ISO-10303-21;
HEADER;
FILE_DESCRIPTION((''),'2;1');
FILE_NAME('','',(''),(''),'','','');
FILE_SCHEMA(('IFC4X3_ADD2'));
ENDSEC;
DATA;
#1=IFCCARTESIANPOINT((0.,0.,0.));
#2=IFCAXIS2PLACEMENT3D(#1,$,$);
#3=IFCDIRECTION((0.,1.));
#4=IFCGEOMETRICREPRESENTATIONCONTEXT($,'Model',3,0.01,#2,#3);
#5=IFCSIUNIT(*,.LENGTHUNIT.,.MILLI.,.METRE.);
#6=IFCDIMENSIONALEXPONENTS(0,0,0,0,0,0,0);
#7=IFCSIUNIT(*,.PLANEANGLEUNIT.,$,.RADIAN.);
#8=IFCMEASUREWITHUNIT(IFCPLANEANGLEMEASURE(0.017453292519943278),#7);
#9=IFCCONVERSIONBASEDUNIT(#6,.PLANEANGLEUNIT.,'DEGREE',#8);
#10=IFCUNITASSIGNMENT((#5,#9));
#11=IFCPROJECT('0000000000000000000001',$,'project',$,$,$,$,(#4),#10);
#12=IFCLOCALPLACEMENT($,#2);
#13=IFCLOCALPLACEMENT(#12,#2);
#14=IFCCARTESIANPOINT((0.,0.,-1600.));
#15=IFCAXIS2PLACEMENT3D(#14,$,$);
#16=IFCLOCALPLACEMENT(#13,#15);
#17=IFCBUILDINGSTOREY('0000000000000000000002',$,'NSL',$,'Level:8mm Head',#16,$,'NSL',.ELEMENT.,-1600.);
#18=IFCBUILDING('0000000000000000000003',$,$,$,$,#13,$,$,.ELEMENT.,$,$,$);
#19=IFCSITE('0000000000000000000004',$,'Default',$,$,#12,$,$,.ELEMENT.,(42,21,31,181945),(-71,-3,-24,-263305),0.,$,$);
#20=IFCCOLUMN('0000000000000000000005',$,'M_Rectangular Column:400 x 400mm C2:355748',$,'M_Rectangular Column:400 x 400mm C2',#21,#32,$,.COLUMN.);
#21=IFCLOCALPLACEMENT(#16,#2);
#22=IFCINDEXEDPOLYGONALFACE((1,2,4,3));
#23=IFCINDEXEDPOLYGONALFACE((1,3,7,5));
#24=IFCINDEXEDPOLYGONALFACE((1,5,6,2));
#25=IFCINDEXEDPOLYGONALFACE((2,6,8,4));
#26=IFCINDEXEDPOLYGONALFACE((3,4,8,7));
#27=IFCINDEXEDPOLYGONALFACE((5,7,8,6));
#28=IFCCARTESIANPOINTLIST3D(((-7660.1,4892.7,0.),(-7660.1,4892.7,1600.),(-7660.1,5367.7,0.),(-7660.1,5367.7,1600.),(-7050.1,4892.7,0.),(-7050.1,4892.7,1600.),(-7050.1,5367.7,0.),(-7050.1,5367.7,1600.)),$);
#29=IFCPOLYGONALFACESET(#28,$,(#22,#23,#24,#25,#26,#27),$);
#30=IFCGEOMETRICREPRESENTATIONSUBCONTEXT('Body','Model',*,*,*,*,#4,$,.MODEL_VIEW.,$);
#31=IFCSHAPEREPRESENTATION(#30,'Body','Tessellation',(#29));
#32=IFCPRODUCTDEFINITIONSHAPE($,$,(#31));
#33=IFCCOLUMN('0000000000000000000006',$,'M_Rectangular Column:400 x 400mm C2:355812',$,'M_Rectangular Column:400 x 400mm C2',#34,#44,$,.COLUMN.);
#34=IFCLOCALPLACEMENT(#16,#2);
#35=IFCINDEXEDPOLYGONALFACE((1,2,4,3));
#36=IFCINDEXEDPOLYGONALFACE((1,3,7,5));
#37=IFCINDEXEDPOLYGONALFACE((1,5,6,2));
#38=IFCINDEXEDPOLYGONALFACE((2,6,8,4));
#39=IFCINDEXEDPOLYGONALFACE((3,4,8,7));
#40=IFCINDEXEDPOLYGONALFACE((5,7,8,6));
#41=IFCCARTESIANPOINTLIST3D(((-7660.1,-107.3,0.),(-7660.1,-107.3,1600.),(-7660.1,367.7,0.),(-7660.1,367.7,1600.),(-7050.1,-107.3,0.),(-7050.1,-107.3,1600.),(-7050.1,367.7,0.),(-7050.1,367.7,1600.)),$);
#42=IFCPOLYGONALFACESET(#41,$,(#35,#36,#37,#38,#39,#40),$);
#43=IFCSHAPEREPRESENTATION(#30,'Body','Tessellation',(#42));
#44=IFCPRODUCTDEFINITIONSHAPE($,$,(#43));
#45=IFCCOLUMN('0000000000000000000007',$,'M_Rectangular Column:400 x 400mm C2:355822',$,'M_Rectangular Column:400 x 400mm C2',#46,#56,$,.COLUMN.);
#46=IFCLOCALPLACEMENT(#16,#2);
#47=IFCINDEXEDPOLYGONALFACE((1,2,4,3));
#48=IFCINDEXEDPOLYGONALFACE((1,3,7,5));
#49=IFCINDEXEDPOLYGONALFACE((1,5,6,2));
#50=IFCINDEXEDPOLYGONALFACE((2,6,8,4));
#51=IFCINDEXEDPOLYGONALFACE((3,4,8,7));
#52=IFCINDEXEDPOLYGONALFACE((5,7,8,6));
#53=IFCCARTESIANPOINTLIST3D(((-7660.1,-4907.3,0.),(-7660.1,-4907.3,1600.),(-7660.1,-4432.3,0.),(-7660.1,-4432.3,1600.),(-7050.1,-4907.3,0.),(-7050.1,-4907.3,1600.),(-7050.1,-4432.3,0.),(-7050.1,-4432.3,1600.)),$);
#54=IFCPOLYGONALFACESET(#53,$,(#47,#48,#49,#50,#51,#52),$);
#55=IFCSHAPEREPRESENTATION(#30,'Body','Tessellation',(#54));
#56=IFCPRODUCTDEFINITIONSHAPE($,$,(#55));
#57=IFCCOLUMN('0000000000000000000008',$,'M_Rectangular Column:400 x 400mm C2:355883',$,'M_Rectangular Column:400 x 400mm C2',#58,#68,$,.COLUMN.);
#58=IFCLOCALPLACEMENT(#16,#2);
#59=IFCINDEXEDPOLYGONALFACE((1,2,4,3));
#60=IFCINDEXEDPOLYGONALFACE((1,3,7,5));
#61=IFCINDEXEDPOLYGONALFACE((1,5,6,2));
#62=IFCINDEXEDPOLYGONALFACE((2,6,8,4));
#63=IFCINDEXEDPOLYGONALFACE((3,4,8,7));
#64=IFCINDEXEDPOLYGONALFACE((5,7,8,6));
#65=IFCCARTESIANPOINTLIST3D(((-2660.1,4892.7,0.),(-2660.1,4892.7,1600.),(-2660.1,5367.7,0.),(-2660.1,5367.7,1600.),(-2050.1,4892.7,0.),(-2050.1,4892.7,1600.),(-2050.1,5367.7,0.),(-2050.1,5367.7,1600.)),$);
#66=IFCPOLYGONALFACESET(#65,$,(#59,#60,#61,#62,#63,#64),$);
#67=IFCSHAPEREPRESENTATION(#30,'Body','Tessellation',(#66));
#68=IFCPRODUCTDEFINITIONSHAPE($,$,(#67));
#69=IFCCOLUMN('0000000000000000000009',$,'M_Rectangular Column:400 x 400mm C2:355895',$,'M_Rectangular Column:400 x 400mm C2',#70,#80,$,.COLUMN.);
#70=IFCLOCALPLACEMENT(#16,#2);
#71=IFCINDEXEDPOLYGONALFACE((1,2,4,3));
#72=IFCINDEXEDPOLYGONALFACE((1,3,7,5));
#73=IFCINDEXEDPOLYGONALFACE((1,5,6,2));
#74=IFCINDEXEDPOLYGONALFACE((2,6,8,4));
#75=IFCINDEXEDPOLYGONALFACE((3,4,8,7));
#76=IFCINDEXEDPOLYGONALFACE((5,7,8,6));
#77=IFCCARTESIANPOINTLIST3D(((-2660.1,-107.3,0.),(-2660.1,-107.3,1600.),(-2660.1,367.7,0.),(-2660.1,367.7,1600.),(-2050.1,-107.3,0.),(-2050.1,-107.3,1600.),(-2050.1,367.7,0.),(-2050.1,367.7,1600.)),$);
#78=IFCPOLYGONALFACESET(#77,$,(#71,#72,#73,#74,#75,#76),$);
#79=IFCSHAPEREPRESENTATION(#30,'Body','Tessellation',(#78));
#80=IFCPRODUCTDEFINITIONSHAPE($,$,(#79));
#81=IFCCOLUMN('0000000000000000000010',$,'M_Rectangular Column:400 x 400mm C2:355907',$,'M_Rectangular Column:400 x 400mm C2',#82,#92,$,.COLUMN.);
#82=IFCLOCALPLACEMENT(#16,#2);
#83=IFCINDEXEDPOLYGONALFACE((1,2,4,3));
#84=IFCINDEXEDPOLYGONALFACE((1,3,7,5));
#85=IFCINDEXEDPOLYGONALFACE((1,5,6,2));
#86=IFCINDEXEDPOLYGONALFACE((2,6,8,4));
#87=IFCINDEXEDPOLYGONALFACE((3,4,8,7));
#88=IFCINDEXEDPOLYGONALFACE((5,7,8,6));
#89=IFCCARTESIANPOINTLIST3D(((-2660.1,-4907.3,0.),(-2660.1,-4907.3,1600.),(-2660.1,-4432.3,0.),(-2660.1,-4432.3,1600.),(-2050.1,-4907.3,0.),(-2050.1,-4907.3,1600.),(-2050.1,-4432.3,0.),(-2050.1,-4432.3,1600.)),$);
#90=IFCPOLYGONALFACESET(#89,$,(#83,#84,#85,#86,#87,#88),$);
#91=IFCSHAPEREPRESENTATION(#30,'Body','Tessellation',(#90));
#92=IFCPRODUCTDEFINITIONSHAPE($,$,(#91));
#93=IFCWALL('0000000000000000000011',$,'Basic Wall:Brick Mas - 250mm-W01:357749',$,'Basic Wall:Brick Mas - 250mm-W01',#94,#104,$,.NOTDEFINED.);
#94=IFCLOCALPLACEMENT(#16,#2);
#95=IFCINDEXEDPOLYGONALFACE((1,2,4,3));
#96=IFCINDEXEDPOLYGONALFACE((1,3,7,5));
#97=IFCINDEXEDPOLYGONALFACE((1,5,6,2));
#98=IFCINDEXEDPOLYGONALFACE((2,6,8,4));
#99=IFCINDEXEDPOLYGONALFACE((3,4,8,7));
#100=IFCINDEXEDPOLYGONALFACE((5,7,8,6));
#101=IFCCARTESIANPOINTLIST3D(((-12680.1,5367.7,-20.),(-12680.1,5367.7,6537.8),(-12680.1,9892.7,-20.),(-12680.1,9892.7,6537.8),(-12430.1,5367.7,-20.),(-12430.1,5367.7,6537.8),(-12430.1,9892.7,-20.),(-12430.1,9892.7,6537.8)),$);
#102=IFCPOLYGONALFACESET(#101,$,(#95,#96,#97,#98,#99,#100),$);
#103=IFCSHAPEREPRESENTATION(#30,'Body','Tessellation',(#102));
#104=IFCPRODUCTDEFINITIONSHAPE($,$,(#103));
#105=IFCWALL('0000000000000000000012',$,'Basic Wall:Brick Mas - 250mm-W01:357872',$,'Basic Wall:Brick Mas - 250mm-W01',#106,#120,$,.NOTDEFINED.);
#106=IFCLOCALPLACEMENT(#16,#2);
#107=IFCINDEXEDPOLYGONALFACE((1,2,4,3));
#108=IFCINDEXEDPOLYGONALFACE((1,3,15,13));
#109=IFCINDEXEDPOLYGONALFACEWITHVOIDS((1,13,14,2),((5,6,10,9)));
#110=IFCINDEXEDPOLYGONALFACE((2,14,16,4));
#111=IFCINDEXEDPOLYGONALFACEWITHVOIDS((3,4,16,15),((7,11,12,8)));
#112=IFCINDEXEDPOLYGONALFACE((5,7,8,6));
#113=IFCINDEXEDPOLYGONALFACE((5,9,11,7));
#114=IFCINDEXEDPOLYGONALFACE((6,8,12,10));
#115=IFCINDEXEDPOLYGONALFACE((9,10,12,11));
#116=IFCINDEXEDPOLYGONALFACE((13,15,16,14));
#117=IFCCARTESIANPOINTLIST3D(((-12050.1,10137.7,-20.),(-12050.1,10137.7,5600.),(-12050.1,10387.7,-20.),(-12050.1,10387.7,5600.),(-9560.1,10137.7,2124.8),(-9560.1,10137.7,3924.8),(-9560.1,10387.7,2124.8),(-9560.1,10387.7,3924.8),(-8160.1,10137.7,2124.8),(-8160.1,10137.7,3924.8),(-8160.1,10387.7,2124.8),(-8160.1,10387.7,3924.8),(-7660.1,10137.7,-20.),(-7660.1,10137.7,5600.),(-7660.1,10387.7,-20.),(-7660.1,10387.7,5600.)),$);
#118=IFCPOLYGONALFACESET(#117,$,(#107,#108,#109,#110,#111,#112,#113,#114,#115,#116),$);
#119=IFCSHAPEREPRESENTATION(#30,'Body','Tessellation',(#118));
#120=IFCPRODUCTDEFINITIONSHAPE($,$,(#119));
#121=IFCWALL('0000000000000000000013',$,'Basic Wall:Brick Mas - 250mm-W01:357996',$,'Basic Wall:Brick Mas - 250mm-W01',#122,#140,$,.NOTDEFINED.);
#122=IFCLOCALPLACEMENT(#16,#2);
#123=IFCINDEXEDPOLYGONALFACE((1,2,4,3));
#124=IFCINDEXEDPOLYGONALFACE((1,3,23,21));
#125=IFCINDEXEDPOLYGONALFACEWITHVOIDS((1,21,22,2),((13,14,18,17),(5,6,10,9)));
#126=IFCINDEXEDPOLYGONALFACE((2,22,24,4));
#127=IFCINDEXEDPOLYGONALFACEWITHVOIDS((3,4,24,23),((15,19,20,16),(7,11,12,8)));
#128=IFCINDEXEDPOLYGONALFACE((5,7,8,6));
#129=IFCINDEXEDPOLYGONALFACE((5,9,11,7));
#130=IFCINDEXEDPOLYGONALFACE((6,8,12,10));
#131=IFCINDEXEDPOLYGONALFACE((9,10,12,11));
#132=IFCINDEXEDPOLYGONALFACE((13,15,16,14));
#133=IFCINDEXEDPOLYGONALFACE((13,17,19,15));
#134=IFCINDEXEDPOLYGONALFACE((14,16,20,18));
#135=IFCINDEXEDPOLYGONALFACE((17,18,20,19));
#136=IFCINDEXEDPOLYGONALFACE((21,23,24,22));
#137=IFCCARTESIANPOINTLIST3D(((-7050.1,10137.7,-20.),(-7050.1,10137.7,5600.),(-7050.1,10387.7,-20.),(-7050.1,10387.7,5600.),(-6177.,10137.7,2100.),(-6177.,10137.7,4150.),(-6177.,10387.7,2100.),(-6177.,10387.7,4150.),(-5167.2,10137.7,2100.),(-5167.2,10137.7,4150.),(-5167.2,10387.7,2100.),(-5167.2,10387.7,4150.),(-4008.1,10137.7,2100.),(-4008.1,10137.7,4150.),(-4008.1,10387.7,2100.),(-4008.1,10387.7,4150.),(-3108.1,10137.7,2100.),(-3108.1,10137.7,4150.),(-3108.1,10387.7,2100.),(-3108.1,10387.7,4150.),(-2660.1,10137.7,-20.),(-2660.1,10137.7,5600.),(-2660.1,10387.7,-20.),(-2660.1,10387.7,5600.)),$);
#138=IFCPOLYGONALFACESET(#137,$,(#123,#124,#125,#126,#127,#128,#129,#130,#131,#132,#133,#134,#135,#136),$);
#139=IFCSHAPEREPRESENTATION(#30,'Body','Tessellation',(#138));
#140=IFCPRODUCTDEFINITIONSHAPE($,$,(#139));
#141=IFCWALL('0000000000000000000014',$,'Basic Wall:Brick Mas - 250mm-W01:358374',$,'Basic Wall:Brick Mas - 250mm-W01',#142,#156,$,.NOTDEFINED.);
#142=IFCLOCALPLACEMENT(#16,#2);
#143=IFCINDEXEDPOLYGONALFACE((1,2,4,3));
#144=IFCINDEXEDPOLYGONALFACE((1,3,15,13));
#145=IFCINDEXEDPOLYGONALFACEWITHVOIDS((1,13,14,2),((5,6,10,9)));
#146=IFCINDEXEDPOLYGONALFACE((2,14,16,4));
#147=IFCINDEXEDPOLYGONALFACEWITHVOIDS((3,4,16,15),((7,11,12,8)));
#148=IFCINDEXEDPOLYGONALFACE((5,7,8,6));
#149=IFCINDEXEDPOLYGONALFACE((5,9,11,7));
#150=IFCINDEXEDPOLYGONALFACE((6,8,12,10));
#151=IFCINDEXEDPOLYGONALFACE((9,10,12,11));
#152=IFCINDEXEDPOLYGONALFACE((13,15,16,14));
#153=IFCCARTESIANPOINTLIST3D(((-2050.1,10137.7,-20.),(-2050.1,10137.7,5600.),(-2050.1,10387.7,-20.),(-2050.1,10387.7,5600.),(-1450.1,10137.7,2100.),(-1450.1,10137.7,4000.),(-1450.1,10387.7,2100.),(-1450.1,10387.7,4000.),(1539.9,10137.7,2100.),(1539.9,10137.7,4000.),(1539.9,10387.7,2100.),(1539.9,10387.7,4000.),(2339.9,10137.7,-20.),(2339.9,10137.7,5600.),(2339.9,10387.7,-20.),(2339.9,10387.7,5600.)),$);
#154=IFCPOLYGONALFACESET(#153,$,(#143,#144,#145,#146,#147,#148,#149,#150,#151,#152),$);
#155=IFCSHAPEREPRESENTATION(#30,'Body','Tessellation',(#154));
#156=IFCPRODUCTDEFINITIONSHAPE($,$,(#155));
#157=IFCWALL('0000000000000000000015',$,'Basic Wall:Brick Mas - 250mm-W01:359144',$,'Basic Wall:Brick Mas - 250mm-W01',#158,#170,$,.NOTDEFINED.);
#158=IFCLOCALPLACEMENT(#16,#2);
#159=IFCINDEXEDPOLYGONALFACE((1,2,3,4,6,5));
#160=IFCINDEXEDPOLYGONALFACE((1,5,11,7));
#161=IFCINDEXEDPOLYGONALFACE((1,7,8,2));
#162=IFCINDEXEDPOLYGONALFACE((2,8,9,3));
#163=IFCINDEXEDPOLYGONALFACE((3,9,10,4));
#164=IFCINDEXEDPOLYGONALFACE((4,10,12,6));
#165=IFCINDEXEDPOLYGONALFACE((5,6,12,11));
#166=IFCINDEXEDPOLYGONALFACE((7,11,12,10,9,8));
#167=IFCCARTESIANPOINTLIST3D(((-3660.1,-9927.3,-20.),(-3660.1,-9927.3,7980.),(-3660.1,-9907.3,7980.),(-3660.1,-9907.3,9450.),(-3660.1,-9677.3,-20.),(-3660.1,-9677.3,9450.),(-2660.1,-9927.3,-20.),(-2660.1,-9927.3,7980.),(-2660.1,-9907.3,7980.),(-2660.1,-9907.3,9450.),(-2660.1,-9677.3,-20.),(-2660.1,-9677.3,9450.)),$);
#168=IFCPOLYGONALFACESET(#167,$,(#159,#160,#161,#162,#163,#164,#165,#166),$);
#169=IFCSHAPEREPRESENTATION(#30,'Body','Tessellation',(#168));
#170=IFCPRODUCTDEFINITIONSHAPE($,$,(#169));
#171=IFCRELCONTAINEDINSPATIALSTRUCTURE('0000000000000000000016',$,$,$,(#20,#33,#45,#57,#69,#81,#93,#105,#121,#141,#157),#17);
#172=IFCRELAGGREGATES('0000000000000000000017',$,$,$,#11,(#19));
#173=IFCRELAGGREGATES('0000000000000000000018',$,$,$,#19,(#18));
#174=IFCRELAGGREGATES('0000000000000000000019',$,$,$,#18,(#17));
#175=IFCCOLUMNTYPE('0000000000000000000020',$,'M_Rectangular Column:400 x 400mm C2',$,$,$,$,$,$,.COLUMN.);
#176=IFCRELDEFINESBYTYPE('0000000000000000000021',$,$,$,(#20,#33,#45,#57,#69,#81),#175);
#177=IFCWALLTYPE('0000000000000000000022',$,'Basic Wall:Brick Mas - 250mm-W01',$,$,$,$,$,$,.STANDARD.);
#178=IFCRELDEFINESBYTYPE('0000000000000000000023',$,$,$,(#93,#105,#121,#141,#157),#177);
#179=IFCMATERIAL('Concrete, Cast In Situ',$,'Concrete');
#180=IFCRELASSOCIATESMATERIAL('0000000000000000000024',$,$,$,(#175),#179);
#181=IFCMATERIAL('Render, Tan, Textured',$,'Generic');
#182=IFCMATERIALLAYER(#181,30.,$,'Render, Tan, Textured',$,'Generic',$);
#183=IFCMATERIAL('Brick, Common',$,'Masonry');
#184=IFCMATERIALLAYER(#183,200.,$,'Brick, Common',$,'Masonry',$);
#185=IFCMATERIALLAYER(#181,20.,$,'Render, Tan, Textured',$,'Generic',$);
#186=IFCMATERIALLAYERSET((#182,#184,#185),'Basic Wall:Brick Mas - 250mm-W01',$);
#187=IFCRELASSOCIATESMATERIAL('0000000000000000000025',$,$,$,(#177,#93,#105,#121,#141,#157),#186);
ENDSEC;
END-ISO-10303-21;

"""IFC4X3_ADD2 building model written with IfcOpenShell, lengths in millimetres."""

from ifc_helpers import new_model, entity, si_unit, converted_unit, direction, frame, frame_2d, origin, origin_2d_with_axis, place, context, subcontext, project, spatial, polyline, rectangle, extrude, clip, bounded_halfspace, source, transform, mapped, material, layer, layer_set, material_profile, profile_set, type_object, type_shapes, element, save


model = new_model("IFC4X3_ADD2")

# Units and contexts
model_context = context("Model", 3, precision=0.01, world=origin(), true_north=direction((0.0, 1.0)))
body_context = subcontext(model_context, "Body", "Model", "MODEL_VIEW")
ifc_project = project(units=[si_unit("LENGTHUNIT", "METRE", prefix="MILLI"), converted_unit("PLANEANGLEUNIT", "DEGREE", entity("IfcPlaneAngleMeasure", 0.017453292519943278), si_unit("PLANEANGLEUNIT", "RADIAN"), dimensions=[0, 0, 0, 0, 0, 0, 0])], contexts=[model_context])

# Site, building, storey
site_placement = place(None, origin())
site = spatial("IfcSite", under=ifc_project, at=site_placement, Name="Default", CompositionType="ELEMENT", RefLatitude=(42, 21, 31, 181945), RefLongitude=(-71, -3, -24, -263305), RefElevation=0.0)
building_placement = place(site_placement, origin())
building = spatial("IfcBuilding", under=site, at=building_placement, CompositionType="ELEMENT")
storey_placement = place(building_placement, frame((0.0, 0.0, -1600.0)))
storey = spatial("IfcBuildingStorey", under=building, at=storey_placement, Name="NSL", ObjectType="Level:8mm Head", LongName="NSL", CompositionType="ELEMENT", Elevation=-1600.0)

# Columns
ifc_material_1 = material(Name="Concrete, Cast In Situ", Category="Concrete")
ifc_material_profile_1 = material_profile(ifc_material_1, rectangle(XDim=610.0, YDim=475.0, at=origin_2d_with_axis()), Name="400 x 400mm C2")
ifc_profile_set_1 = profile_set([ifc_material_profile_1], Name="400 x 400mm C2")
column_type_1 = type_object("IfcColumnType", Name="M_Rectangular Column:400 x 400mm C2", PredefinedType="COLUMN", material=ifc_profile_set_1)
shared_shape_1 = source(origin(), body_context, "Body", "SweptSolid", [
    extrude(rectangle(XDim=610.0, YDim=475.0, at=origin_2d_with_axis()), frame((0.0, 0.0, -1600.0), z_axis=(0.0, 0.0, 1.0), x_axis=(-1.0, 0.0, 0.0)), (0.0, 0.0, 1.0), 1600.0),
])
type_shapes(column_type_1, [shared_shape_1])
for number, where, name in (
    (1, (-7355.1, 5130.2, 1600.0), "M_Rectangular Column:400 x 400mm C2:355748"),
    (2, (-7355.1, 130.2, 1600.0), "M_Rectangular Column:400 x 400mm C2:355812"),
    (3, (-7355.1, -4669.8, 1600.0), "M_Rectangular Column:400 x 400mm C2:355822"),
    (4, (-2355.1, 5130.2, 1600.0), "M_Rectangular Column:400 x 400mm C2:355883"),
    (5, (-2355.1, 130.2, 1600.0), "M_Rectangular Column:400 x 400mm C2:355895"),
    (6, (-2355.1, -4669.8, 1600.0), "M_Rectangular Column:400 x 400mm C2:355907"),
):
    element("IfcColumn", number, at=place(storey_placement, frame(where)), inside=storey, type_object=column_type_1, Name=name, ObjectType="M_Rectangular Column:400 x 400mm C2", PredefinedType="COLUMN", context=body_context, shape_type="MappedRepresentation", body=[
        mapped(shared_shape_1, transform((0.0, 0.0, 0.0), scale=1.0)),
    ])

# Wall
ifc_material_2 = material(Name="Render, Tan, Textured", Category="Generic")
ifc_layer_1 = layer(ifc_material_2, 30.0, Name="Render, Tan, Textured", Category="Generic")
ifc_material_3 = material(Name="Brick, Common", Category="Masonry")
ifc_layer_2 = layer(ifc_material_3, 200.0, Name="Brick, Common", Category="Masonry")
ifc_layer_3 = layer(ifc_material_2, 20.0, Name="Render, Tan, Textured", Category="Generic")
ifc_layer_set = layer_set([ifc_layer_1, ifc_layer_2, ifc_layer_3], Name="Basic Wall:Brick Mas - 250mm-W01")
wall_type = type_object("IfcWallType", Name="Basic Wall:Brick Mas - 250mm-W01", PredefinedType="STANDARD", material=ifc_layer_set)
wall_1_placement = place(storey_placement, frame((-12555.1, 9892.7, -20.0), z_axis=(0.0, 0.0, 1.0), x_axis=(0.0, -1.0, 0.0)))
element("IfcWall", 7, at=wall_1_placement, inside=storey, type_object=wall_type, material=ifc_layer_set, Name="Basic Wall:Brick Mas - 250mm-W01:357749", ObjectType="Basic Wall:Brick Mas - 250mm-W01", PredefinedType="NOTDEFINED", context=body_context, shape_type="SweptSolid", body=[
    extrude(rectangle(XDim=4525.0, YDim=250.0, at=frame_2d((2262.5, 0.0), x_axis=(-1.0, 0.0))), origin(), (0.0, 0.0, 1.0), 6557.8),
])

# Wall, opening
wall_2_placement = place(storey_placement, frame((-12050.1, 10262.7, -20.0)))
wall_2 = element("IfcWall", 8, at=wall_2_placement, inside=storey, type_object=wall_type, material=ifc_layer_set, Name="Basic Wall:Brick Mas - 250mm-W01:357872", ObjectType="Basic Wall:Brick Mas - 250mm-W01", PredefinedType="NOTDEFINED", context=body_context, shape_type="SweptSolid", body=[
    extrude(rectangle(XDim=4390.0, YDim=250.0, at=frame_2d((2195.0, 0.0), x_axis=(-1.0, 0.0))), origin(), (0.0, 0.0, 1.0), 5620.0),
])
opening_1_placement = place(wall_2_placement, frame((2490.0, -125.0, 2144.8)))
element("IfcOpeningElement", 9, at=opening_1_placement, cuts=wall_2, PredefinedType="OPENING", context=body_context, shape_type="SweptSolid", body=[
    extrude(rectangle(XDim=1800.0, YDim=1400.0, at=frame_2d((900.0, 700.0), x_axis=(-1.0, 0.0))), frame((0.0, 0.0, 0.0), z_axis=(0.0, 1.0, 0.0), x_axis=(0.0, 0.0, 1.0)), (0.0, 0.0, 1.0), 250.0),
])

# Wall, openings
wall_3_placement = place(storey_placement, frame((-7050.1, 10262.7, -20.0)))
wall_3 = element("IfcWall", 10, at=wall_3_placement, inside=storey, type_object=wall_type, material=ifc_layer_set, Name="Basic Wall:Brick Mas - 250mm-W01:357996", ObjectType="Basic Wall:Brick Mas - 250mm-W01", PredefinedType="NOTDEFINED", context=body_context, shape_type="SweptSolid", body=[
    extrude(rectangle(XDim=4390.0, YDim=250.0, at=frame_2d((2195.0, 0.0), x_axis=(-1.0, 0.0))), origin(), (0.0, 0.0, 1.0), 5620.0),
])
opening_2_placement = place(wall_3_placement, origin())
element("IfcOpeningElement", 11, at=opening_2_placement, cuts=wall_3, PredefinedType="OPENING", context=body_context, shape_type="SweptSolid", body=[
    extrude(rectangle(XDim=2050.0, YDim=900.0, at=frame_2d((0.0, 0.0), x_axis=(0.0, 1.0))), frame((3492.0, 125.0, 3145.0), z_axis=(0.0, -1.0, 0.0), x_axis=(1.0, 0.0, 0.0)), (0.0, 0.0, 1.0), 250.0),
])
opening_3_placement = place(wall_3_placement, origin())
element("IfcOpeningElement", 12, at=opening_3_placement, cuts=wall_3, PredefinedType="OPENING", context=body_context, shape_type="SweptSolid", body=[
    extrude(rectangle(XDim=2050.0, YDim=1009.8, at=frame_2d((0.0, 0.0), x_axis=(0.0, 1.0))), frame((1378.0, 125.0, 3145.0), z_axis=(0.0, -1.0, 0.0), x_axis=(1.0, 0.0, 0.0)), (0.0, 0.0, 1.0), 250.0),
])

# Wall, opening
wall_4_placement = place(storey_placement, frame((-2050.1, 10262.7, -20.0)))
wall_4 = element("IfcWall", 13, at=wall_4_placement, inside=storey, type_object=wall_type, material=ifc_layer_set, Name="Basic Wall:Brick Mas - 250mm-W01:358374", ObjectType="Basic Wall:Brick Mas - 250mm-W01", PredefinedType="NOTDEFINED", context=body_context, shape_type="SweptSolid", body=[
    extrude(rectangle(XDim=4390.0, YDim=250.0, at=frame_2d((2195.0, 0.0), x_axis=(-1.0, 0.0))), origin(), (0.0, 0.0, 1.0), 5620.0),
])
opening_4_placement = place(wall_4_placement, origin())
element("IfcOpeningElement", 14, at=opening_4_placement, cuts=wall_4, PredefinedType="OPENING", context=body_context, shape_type="SweptSolid", body=[
    extrude(rectangle(XDim=1900.0, YDim=2990.0, at=frame_2d((0.0, 0.0), x_axis=(0.0, 1.0))), frame((2095.0, 125.0, 3070.0), z_axis=(0.0, -1.0, 0.0), x_axis=(1.0, 0.0, 0.0)), (0.0, 0.0, 1.0), 250.0),
])

# Wall
wall_5_placement = place(storey_placement, frame((-2660.1, -9802.3, -20.0), z_axis=(0.0, 0.0, 1.0), x_axis=(-1.0, 0.0, 0.0)))
element("IfcWall", 15, at=wall_5_placement, inside=storey, type_object=wall_type, material=ifc_layer_set, Name="Basic Wall:Brick Mas - 250mm-W01:359144", ObjectType="Basic Wall:Brick Mas - 250mm-W01", PredefinedType="NOTDEFINED", context=body_context, shape_type="Clipping", body=[
    clip(clip(extrude(rectangle(XDim=1000.0, YDim=250.0, at=frame_2d((500.0, 0.0), x_axis=(-1.0, 0.0))), origin(), (0.0, 0.0, 1.0), 9470.0), bounded_halfspace(frame((0.0, -125.0, 9470.0), z_axis=(0.0, 0.0, -1.0), x_axis=(0.0, 1.0, 0.0)), True, frame((0.0, -125.0, 9470.0)), polyline([(0.0, 0.0), (1000.0, 0.0), (1000.0, 230.0), (0.0, 230.0), (0.0, 0.0)]))), bounded_halfspace(frame((1000.0, 105.0, 8000.0), z_axis=(0.0, 0.0, 1.0), x_axis=(0.0, 1.0, 0.0)), False, frame((1000.0, 105.0, 8000.0)), polyline([(0.0, 0.0), (0.0, 20.0), (-1000.0, 20.0), (-1000.0, 0.0), (0.0, 0.0)]))),
])

save(model, "model.ifc")
